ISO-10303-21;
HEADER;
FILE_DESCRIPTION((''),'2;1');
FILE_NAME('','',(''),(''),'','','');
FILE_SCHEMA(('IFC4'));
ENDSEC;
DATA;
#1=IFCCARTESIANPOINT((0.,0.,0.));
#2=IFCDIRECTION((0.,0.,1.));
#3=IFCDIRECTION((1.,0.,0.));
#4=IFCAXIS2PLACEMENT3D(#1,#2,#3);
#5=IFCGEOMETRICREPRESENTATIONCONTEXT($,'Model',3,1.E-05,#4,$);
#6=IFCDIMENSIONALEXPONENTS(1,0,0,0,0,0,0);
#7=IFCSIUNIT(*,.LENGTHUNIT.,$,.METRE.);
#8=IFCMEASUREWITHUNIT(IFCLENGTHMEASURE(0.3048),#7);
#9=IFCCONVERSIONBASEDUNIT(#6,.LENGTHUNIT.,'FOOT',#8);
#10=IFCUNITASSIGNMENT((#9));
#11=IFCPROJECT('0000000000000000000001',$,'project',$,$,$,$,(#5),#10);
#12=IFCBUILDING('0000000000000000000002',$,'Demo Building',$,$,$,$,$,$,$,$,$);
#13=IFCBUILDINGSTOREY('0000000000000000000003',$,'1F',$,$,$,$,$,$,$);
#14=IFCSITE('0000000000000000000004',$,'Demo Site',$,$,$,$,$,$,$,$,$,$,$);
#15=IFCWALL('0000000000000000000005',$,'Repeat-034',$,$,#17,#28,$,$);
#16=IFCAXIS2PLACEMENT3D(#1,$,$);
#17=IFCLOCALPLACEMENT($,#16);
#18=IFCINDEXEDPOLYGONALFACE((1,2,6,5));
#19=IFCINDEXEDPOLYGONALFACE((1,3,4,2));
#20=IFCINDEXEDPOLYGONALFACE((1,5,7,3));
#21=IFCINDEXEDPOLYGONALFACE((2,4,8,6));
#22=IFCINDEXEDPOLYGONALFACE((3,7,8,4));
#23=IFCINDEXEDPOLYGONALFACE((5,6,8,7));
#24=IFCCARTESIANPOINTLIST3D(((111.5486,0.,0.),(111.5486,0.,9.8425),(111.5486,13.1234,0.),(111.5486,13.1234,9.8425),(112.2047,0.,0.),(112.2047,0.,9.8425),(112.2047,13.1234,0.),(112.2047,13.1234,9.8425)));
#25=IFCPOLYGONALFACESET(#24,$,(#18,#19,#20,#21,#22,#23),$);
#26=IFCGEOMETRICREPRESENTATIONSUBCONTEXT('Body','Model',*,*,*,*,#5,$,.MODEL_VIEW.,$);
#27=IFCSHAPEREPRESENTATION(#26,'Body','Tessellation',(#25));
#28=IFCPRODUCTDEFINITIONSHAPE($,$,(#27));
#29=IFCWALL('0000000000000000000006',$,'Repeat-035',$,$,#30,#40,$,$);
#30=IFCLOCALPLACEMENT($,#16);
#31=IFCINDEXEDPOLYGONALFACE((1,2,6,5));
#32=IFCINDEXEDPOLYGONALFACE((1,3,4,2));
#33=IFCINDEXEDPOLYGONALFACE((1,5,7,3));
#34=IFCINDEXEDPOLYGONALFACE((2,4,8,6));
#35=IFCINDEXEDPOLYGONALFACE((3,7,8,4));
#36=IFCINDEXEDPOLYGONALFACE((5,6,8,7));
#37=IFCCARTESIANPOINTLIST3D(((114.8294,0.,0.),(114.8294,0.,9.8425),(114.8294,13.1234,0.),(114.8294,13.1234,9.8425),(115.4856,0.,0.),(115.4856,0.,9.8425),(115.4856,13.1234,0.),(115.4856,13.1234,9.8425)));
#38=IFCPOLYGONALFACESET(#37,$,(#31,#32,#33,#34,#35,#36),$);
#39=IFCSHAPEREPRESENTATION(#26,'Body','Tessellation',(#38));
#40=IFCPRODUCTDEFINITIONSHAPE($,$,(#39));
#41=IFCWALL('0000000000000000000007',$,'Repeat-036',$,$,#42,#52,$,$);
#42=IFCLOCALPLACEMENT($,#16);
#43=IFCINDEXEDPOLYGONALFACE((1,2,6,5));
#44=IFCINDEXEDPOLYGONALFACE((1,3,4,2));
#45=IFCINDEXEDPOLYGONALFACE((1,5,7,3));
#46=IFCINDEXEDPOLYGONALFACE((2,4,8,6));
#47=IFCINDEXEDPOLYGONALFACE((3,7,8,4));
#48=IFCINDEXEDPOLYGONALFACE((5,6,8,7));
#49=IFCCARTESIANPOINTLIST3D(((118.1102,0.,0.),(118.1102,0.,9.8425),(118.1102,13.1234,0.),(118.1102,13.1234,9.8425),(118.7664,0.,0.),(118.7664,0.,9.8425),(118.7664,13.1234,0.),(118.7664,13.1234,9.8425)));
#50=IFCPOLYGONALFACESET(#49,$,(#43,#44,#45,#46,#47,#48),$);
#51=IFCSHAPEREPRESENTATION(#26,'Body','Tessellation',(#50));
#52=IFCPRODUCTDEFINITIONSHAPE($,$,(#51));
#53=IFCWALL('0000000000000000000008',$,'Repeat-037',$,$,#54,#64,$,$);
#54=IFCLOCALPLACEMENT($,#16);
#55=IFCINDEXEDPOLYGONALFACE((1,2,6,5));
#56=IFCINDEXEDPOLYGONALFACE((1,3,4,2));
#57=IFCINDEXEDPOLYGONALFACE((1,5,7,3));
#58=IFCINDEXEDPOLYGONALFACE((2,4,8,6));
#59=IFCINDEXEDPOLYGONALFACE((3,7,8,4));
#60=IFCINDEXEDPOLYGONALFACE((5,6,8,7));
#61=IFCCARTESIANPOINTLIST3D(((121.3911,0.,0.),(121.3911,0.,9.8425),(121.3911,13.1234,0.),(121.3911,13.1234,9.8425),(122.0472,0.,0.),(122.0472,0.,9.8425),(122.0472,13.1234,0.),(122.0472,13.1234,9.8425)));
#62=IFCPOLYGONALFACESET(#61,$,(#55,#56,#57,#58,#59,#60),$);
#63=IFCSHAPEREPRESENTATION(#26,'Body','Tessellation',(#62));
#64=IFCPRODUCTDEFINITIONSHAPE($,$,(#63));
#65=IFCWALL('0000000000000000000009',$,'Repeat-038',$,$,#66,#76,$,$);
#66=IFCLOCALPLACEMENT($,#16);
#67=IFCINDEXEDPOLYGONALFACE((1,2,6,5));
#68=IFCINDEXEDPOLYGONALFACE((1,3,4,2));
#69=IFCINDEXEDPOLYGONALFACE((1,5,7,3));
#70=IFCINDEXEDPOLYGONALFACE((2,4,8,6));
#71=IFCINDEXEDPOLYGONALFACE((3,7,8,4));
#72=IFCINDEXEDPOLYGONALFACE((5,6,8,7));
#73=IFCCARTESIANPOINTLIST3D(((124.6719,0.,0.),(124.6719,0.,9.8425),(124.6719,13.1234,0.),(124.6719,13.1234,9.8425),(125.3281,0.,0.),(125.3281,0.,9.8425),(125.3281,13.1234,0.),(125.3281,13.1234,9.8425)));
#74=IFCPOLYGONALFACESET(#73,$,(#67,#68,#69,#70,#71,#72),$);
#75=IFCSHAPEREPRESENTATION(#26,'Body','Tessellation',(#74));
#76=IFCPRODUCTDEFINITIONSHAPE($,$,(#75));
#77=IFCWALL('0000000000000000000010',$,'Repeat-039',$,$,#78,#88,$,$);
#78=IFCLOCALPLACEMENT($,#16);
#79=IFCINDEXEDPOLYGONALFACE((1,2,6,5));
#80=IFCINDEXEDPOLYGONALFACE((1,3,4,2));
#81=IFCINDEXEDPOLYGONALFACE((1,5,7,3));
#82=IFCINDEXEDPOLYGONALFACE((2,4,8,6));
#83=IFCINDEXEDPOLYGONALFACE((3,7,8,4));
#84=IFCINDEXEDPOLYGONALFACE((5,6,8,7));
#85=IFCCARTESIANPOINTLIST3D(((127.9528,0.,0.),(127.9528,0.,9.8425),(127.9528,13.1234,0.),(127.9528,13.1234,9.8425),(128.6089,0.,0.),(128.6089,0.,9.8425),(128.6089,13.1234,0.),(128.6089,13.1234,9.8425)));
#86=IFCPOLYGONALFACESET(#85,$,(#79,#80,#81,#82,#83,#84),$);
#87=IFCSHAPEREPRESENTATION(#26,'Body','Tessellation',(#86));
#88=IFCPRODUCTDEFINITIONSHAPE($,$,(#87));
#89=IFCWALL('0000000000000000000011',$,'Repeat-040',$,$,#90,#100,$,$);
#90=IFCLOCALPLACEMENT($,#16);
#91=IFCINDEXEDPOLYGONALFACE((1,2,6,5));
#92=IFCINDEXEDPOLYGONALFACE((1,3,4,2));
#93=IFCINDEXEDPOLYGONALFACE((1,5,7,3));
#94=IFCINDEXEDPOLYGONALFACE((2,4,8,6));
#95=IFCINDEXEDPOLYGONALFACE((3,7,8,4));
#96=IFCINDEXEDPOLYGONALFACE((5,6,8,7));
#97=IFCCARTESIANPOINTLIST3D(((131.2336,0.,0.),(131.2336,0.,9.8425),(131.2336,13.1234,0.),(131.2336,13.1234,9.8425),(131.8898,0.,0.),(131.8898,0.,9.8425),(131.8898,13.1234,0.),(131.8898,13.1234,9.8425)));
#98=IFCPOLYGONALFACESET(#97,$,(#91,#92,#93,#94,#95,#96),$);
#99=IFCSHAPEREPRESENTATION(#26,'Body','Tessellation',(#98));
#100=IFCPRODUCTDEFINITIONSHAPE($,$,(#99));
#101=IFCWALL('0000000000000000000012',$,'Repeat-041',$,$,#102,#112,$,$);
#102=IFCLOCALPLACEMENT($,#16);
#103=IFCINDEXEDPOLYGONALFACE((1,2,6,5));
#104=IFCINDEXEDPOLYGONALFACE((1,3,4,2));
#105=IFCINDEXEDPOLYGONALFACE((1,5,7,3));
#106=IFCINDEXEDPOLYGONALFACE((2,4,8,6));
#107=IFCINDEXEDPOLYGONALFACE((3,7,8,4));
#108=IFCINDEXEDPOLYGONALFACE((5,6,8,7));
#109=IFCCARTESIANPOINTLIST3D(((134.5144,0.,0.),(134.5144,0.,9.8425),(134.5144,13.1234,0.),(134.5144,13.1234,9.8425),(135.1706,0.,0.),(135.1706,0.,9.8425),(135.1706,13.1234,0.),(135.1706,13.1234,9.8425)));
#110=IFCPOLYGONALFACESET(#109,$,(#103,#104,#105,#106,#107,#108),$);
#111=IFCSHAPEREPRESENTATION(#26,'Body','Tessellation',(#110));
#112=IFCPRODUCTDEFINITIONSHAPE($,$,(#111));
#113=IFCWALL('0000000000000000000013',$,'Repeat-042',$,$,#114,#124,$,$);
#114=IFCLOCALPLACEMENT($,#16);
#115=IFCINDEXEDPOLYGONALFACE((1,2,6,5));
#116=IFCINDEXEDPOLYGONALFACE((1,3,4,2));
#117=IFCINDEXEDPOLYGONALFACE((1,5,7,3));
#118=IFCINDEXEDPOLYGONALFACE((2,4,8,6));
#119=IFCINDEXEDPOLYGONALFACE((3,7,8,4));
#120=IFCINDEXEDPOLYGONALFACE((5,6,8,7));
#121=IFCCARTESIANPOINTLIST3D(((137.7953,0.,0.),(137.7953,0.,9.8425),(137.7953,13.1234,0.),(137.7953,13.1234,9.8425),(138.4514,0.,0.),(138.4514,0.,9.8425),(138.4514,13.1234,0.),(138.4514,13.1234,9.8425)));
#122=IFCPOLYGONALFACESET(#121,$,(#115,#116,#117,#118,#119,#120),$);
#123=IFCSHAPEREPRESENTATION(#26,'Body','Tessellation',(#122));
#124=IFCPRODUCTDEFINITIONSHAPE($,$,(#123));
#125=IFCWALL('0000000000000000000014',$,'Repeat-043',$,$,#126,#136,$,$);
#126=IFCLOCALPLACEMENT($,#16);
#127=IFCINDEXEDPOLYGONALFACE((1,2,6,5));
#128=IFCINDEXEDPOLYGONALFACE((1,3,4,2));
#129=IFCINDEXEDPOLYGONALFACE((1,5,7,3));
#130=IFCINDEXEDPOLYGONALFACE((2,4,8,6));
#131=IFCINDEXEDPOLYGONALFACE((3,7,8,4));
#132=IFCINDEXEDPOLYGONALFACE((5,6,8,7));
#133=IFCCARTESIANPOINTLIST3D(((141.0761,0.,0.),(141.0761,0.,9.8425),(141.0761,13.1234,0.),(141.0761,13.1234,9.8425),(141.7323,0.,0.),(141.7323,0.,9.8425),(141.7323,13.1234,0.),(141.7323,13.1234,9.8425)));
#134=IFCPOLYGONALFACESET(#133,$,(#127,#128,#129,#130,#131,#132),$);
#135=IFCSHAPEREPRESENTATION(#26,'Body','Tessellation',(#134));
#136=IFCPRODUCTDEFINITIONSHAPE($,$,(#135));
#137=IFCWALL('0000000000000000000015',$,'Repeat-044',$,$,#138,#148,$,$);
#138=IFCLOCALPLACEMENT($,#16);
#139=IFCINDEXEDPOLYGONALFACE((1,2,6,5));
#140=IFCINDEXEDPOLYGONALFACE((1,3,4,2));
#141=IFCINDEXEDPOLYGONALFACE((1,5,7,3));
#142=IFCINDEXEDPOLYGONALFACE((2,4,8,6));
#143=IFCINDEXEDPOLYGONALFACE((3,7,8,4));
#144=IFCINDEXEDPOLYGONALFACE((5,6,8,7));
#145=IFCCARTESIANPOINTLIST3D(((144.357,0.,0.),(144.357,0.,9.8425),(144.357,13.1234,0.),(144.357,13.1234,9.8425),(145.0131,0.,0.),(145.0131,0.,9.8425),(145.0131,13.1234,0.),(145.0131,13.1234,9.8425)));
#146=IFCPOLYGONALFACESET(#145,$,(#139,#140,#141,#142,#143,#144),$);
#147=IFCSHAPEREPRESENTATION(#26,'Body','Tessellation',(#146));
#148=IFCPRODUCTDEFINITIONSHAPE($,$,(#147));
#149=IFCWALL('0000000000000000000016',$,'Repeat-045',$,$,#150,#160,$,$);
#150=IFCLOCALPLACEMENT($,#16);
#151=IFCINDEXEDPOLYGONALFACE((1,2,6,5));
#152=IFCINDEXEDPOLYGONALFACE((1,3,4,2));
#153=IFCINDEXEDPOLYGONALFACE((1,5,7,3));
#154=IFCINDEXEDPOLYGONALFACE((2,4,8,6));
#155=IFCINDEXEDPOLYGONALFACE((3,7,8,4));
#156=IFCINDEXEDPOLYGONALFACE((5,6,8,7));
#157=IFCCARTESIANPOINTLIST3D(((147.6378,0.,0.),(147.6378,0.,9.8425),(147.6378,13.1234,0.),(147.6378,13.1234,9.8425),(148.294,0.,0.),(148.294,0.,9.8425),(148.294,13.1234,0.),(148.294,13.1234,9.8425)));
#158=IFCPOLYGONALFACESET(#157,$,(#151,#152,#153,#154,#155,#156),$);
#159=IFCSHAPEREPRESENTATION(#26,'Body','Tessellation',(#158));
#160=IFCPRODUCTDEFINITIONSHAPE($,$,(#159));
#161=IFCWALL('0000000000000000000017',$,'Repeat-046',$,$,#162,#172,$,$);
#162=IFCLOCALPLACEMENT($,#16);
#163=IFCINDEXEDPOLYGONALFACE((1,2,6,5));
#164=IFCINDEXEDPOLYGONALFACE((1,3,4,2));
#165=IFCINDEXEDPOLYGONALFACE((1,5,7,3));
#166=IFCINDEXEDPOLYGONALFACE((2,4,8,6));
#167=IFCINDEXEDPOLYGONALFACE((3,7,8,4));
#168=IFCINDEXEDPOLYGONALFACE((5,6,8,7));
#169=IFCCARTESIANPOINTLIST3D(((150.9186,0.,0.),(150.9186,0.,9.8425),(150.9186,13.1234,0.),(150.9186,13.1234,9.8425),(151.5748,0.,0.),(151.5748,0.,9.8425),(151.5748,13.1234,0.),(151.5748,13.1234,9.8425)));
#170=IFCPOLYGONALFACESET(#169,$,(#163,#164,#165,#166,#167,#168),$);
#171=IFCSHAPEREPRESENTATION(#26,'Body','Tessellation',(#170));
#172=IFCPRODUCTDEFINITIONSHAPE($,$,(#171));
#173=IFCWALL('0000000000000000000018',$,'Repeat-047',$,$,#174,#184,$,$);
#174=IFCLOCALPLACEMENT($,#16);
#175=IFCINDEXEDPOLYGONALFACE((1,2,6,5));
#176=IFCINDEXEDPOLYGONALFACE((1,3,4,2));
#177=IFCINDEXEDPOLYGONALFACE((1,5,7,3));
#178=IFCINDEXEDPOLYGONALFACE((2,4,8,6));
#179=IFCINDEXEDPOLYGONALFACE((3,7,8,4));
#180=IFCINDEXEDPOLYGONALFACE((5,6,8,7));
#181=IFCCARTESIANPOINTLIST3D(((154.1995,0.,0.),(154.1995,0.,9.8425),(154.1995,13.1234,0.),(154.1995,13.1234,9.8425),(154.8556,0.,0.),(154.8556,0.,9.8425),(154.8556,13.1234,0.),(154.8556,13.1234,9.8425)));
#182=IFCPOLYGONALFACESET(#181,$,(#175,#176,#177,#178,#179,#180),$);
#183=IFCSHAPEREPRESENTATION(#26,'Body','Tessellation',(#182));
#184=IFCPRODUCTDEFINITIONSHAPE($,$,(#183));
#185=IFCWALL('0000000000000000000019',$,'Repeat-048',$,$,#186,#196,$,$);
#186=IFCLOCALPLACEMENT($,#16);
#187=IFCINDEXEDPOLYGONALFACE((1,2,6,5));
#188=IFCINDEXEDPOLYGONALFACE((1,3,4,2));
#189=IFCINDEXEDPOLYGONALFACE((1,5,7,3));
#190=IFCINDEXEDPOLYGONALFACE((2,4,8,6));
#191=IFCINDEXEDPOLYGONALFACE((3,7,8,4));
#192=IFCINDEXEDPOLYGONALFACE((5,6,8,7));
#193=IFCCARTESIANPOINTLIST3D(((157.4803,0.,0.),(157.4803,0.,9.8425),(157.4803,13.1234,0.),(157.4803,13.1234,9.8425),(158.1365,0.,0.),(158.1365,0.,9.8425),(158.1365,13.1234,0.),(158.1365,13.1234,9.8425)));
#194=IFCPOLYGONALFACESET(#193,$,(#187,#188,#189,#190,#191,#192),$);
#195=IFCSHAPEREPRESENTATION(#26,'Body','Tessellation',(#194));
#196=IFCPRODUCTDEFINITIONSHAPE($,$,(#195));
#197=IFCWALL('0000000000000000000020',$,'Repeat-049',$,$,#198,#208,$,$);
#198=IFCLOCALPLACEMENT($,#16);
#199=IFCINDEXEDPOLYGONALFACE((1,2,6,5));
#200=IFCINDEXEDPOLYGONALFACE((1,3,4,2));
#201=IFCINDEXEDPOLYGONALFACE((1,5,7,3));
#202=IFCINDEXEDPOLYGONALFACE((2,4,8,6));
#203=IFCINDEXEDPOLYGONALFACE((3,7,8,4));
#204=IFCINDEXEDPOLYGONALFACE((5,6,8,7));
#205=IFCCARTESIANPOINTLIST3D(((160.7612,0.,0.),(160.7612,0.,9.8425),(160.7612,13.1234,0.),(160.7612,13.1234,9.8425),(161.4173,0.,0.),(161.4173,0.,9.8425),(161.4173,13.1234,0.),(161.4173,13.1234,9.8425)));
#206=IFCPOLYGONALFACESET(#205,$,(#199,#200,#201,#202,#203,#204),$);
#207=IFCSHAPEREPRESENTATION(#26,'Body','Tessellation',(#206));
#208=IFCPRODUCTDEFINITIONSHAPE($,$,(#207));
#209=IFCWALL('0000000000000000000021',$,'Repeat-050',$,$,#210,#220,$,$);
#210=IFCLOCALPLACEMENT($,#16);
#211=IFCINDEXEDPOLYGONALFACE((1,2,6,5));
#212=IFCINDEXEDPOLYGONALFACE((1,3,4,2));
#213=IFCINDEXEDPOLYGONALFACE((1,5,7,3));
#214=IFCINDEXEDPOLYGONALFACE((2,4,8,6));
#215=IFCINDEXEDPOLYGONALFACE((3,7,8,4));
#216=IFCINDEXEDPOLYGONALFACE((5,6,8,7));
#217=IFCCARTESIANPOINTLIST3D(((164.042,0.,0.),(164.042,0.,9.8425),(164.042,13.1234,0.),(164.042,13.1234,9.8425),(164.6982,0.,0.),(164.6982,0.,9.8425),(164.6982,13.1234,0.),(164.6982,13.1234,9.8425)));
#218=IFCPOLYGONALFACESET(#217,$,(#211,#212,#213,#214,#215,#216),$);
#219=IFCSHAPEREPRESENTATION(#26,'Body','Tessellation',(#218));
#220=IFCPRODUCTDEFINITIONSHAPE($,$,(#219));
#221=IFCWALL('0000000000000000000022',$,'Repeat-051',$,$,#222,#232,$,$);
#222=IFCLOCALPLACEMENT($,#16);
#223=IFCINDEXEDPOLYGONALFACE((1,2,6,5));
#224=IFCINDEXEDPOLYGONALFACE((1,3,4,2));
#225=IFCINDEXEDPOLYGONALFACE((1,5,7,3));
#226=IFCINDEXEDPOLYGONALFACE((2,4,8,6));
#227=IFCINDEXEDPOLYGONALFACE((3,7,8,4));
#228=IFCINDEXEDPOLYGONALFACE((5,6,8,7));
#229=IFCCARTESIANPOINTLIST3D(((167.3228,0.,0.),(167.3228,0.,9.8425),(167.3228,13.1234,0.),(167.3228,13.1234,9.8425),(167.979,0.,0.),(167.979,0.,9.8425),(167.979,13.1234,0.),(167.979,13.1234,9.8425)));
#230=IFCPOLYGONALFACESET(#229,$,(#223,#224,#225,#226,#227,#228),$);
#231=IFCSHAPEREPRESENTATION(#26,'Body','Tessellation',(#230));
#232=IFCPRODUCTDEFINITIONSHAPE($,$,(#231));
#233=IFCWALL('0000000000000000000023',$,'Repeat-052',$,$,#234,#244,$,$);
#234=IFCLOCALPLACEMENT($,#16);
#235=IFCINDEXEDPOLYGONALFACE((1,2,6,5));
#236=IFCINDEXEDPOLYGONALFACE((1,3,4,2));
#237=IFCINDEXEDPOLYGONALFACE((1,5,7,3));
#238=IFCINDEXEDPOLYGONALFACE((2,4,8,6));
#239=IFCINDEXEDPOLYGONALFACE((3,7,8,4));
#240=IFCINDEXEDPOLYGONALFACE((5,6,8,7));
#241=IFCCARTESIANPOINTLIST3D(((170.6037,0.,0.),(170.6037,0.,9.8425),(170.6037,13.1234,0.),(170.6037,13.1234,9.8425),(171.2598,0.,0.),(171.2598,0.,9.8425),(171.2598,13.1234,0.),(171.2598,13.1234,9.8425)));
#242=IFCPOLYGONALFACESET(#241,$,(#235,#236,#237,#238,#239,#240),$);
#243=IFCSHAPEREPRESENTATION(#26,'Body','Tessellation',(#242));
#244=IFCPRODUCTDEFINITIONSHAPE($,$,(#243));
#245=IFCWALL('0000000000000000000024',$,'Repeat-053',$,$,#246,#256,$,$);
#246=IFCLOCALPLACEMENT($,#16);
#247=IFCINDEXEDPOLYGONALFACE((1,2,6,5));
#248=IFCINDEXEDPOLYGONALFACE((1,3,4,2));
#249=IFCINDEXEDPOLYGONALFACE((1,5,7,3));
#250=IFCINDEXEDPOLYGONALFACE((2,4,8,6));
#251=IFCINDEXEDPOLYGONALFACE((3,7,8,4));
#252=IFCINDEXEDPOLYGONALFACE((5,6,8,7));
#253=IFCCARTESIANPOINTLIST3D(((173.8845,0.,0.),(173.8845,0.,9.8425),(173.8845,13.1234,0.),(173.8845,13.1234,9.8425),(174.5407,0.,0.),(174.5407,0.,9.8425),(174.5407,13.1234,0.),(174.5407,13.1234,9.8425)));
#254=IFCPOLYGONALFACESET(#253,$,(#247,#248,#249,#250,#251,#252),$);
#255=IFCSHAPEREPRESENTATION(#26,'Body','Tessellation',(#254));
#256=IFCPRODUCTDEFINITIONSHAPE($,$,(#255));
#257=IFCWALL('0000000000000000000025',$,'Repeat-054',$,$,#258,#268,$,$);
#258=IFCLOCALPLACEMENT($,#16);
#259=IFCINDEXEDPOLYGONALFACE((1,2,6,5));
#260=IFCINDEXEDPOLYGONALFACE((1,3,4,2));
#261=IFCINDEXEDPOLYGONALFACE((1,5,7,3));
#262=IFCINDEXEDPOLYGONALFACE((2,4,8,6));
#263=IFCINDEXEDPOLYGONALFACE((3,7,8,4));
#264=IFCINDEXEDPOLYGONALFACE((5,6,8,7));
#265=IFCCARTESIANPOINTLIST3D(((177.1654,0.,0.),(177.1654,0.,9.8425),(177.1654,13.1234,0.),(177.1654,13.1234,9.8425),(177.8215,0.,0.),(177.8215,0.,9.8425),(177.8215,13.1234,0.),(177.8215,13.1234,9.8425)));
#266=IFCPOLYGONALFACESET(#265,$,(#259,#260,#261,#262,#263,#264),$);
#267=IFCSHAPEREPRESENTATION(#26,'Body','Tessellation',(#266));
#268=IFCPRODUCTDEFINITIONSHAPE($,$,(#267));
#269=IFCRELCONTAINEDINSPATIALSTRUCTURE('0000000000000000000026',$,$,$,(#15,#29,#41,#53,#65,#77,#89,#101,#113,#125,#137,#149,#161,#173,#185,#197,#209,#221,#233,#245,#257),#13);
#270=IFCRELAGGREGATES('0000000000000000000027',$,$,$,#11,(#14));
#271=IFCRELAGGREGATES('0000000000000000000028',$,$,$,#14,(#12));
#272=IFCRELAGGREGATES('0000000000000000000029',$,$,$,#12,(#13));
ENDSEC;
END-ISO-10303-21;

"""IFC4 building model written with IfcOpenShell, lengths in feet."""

from ifc_helpers import new_model, entity, si_unit, converted_unit, frame, origin_with_axes, place, context, subcontext, project, spatial, element, save


model = new_model("IFC4")

# Units and contexts
model_context = context("Model", 3, precision=1e-05, world=origin_with_axes())
body_context = subcontext(model_context, "Body", "Model", "MODEL_VIEW")
ifc_project = project(units=[converted_unit("LENGTHUNIT", "FOOT", entity("IfcLengthMeasure", 0.3048), si_unit("LENGTHUNIT", "METRE"), dimensions=[1, 0, 0, 0, 0, 0, 0])], contexts=[model_context])

# Site, building, storey
site = spatial("IfcSite", under=ifc_project, Name="Demo Site")
building = spatial("IfcBuilding", under=site, Name="Demo Building")
storey = spatial("IfcBuildingStorey", under=building, Name="1F")

# Walls
for number, where, z_axis, x_axis, name in (
    (1, (111.5486, 0.0, 0.0), (0.0, 0.0, 1.0), (1.0, 0.0, 0.0), "Repeat-034"),
    (2, (114.8294, 0.0, 0.0), (0.0, 0.0, 1.0), (1.0, 0.0, 0.0), "Repeat-035"),
    (3, (118.1102, 0.0, 0.0), (0.0, 0.0, 1.0), (1.0, 0.0, 0.0), "Repeat-036"),
    (4, (121.3911, 0.0, 0.0), (0.0, 0.0, 1.0), (1.0, 0.0, 0.0), "Repeat-037"),
    (5, (124.6719, 0.0, 0.0), (0.0, 0.0, 1.0), (1.0, 0.0, 0.0), "Repeat-038"),
    (6, (127.9528, 0.0, 0.0), (0.0, 0.0, 1.0), (1.0, 0.0, 0.0), "Repeat-039"),
    (7, (131.2336, 0.0, 0.0), (0.0, 0.0, 1.0), (1.0, 0.0, 0.0), "Repeat-040"),
    (8, (134.5144, 0.0, 0.0), (0.0, 0.0, 1.0), (1.0, 0.0, 0.0), "Repeat-041"),
    (9, (137.7953, 0.0, 0.0), (0.0, 0.0, 1.0), (1.0, 0.0, 0.0), "Repeat-042"),
    (10, (141.0761, 0.0, 0.0), (0.0, 0.0, 1.0), (1.0, 0.0, 0.0), "Repeat-043"),
    (11, (144.357, 0.0, 0.0), (0.0, 0.0, 1.0), (1.0, 0.0, 0.0), "Repeat-044"),
    (12, (147.6378, 0.0, 0.0), (0.0, 0.0, 1.0), (1.0, 0.0, 0.0), "Repeat-045"),
    (13, (150.9186, 0.0, 0.0), (0.0, 0.0, 1.0), (1.0, 0.0, 0.0), "Repeat-046"),
    (14, (154.1995, 0.0, 0.0), (0.0, 0.0, 1.0), (1.0, 0.0, 0.0), "Repeat-047"),
    (15, (157.4803, 0.0, 0.0), (0.0, 0.0, 1.0), (1.0, 0.0, 0.0), "Repeat-048"),
    (16, (160.7612, 0.0, 0.0), (0.0, 0.0, 1.0), (1.0, 0.0, 0.0), "Repeat-049"),
    (17, (164.042, 0.0, 0.0), (0.0, 0.0, 1.0), (1.0, 0.0, 0.0), "Repeat-050"),
    (18, (167.3228, 0.0, 0.0), (0.0, 0.0, 1.0), (1.0, 0.0, 0.0), "Repeat-051"),
    (19, (170.6037, 0.0, 0.0), (0.0, 0.0, 1.0), (1.0, 0.0, 0.0), "Repeat-052"),
    (20, (173.8845, 0.0, 0.0), (0.0, 0.0, 1.0), (1.0, 0.0, 0.0), "Repeat-053"),
    (21, (177.1654, 0.0, 0.0), (0.0, 0.0, 1.0), (1.0, 0.0, 0.0), "Repeat-054"),
):
    element("IfcWall", number, at=place(None, frame(where, z_axis=z_axis, x_axis=x_axis)), inside=storey, Name=name, context=body_context, shape_type="CSG", body=[
        entity("IfcBlock", entity("IfcAxis2Placement3D", entity("IfcCartesianPoint", [0.0, 0.0, 0.0]), entity("IfcDirection", [0.0, 0.0, 1.0]), entity("IfcDirection", [1.0, 0.0, 0.0])), 0.6562, 13.1234, 9.8425),
    ])

save(model, "model.ifc")
